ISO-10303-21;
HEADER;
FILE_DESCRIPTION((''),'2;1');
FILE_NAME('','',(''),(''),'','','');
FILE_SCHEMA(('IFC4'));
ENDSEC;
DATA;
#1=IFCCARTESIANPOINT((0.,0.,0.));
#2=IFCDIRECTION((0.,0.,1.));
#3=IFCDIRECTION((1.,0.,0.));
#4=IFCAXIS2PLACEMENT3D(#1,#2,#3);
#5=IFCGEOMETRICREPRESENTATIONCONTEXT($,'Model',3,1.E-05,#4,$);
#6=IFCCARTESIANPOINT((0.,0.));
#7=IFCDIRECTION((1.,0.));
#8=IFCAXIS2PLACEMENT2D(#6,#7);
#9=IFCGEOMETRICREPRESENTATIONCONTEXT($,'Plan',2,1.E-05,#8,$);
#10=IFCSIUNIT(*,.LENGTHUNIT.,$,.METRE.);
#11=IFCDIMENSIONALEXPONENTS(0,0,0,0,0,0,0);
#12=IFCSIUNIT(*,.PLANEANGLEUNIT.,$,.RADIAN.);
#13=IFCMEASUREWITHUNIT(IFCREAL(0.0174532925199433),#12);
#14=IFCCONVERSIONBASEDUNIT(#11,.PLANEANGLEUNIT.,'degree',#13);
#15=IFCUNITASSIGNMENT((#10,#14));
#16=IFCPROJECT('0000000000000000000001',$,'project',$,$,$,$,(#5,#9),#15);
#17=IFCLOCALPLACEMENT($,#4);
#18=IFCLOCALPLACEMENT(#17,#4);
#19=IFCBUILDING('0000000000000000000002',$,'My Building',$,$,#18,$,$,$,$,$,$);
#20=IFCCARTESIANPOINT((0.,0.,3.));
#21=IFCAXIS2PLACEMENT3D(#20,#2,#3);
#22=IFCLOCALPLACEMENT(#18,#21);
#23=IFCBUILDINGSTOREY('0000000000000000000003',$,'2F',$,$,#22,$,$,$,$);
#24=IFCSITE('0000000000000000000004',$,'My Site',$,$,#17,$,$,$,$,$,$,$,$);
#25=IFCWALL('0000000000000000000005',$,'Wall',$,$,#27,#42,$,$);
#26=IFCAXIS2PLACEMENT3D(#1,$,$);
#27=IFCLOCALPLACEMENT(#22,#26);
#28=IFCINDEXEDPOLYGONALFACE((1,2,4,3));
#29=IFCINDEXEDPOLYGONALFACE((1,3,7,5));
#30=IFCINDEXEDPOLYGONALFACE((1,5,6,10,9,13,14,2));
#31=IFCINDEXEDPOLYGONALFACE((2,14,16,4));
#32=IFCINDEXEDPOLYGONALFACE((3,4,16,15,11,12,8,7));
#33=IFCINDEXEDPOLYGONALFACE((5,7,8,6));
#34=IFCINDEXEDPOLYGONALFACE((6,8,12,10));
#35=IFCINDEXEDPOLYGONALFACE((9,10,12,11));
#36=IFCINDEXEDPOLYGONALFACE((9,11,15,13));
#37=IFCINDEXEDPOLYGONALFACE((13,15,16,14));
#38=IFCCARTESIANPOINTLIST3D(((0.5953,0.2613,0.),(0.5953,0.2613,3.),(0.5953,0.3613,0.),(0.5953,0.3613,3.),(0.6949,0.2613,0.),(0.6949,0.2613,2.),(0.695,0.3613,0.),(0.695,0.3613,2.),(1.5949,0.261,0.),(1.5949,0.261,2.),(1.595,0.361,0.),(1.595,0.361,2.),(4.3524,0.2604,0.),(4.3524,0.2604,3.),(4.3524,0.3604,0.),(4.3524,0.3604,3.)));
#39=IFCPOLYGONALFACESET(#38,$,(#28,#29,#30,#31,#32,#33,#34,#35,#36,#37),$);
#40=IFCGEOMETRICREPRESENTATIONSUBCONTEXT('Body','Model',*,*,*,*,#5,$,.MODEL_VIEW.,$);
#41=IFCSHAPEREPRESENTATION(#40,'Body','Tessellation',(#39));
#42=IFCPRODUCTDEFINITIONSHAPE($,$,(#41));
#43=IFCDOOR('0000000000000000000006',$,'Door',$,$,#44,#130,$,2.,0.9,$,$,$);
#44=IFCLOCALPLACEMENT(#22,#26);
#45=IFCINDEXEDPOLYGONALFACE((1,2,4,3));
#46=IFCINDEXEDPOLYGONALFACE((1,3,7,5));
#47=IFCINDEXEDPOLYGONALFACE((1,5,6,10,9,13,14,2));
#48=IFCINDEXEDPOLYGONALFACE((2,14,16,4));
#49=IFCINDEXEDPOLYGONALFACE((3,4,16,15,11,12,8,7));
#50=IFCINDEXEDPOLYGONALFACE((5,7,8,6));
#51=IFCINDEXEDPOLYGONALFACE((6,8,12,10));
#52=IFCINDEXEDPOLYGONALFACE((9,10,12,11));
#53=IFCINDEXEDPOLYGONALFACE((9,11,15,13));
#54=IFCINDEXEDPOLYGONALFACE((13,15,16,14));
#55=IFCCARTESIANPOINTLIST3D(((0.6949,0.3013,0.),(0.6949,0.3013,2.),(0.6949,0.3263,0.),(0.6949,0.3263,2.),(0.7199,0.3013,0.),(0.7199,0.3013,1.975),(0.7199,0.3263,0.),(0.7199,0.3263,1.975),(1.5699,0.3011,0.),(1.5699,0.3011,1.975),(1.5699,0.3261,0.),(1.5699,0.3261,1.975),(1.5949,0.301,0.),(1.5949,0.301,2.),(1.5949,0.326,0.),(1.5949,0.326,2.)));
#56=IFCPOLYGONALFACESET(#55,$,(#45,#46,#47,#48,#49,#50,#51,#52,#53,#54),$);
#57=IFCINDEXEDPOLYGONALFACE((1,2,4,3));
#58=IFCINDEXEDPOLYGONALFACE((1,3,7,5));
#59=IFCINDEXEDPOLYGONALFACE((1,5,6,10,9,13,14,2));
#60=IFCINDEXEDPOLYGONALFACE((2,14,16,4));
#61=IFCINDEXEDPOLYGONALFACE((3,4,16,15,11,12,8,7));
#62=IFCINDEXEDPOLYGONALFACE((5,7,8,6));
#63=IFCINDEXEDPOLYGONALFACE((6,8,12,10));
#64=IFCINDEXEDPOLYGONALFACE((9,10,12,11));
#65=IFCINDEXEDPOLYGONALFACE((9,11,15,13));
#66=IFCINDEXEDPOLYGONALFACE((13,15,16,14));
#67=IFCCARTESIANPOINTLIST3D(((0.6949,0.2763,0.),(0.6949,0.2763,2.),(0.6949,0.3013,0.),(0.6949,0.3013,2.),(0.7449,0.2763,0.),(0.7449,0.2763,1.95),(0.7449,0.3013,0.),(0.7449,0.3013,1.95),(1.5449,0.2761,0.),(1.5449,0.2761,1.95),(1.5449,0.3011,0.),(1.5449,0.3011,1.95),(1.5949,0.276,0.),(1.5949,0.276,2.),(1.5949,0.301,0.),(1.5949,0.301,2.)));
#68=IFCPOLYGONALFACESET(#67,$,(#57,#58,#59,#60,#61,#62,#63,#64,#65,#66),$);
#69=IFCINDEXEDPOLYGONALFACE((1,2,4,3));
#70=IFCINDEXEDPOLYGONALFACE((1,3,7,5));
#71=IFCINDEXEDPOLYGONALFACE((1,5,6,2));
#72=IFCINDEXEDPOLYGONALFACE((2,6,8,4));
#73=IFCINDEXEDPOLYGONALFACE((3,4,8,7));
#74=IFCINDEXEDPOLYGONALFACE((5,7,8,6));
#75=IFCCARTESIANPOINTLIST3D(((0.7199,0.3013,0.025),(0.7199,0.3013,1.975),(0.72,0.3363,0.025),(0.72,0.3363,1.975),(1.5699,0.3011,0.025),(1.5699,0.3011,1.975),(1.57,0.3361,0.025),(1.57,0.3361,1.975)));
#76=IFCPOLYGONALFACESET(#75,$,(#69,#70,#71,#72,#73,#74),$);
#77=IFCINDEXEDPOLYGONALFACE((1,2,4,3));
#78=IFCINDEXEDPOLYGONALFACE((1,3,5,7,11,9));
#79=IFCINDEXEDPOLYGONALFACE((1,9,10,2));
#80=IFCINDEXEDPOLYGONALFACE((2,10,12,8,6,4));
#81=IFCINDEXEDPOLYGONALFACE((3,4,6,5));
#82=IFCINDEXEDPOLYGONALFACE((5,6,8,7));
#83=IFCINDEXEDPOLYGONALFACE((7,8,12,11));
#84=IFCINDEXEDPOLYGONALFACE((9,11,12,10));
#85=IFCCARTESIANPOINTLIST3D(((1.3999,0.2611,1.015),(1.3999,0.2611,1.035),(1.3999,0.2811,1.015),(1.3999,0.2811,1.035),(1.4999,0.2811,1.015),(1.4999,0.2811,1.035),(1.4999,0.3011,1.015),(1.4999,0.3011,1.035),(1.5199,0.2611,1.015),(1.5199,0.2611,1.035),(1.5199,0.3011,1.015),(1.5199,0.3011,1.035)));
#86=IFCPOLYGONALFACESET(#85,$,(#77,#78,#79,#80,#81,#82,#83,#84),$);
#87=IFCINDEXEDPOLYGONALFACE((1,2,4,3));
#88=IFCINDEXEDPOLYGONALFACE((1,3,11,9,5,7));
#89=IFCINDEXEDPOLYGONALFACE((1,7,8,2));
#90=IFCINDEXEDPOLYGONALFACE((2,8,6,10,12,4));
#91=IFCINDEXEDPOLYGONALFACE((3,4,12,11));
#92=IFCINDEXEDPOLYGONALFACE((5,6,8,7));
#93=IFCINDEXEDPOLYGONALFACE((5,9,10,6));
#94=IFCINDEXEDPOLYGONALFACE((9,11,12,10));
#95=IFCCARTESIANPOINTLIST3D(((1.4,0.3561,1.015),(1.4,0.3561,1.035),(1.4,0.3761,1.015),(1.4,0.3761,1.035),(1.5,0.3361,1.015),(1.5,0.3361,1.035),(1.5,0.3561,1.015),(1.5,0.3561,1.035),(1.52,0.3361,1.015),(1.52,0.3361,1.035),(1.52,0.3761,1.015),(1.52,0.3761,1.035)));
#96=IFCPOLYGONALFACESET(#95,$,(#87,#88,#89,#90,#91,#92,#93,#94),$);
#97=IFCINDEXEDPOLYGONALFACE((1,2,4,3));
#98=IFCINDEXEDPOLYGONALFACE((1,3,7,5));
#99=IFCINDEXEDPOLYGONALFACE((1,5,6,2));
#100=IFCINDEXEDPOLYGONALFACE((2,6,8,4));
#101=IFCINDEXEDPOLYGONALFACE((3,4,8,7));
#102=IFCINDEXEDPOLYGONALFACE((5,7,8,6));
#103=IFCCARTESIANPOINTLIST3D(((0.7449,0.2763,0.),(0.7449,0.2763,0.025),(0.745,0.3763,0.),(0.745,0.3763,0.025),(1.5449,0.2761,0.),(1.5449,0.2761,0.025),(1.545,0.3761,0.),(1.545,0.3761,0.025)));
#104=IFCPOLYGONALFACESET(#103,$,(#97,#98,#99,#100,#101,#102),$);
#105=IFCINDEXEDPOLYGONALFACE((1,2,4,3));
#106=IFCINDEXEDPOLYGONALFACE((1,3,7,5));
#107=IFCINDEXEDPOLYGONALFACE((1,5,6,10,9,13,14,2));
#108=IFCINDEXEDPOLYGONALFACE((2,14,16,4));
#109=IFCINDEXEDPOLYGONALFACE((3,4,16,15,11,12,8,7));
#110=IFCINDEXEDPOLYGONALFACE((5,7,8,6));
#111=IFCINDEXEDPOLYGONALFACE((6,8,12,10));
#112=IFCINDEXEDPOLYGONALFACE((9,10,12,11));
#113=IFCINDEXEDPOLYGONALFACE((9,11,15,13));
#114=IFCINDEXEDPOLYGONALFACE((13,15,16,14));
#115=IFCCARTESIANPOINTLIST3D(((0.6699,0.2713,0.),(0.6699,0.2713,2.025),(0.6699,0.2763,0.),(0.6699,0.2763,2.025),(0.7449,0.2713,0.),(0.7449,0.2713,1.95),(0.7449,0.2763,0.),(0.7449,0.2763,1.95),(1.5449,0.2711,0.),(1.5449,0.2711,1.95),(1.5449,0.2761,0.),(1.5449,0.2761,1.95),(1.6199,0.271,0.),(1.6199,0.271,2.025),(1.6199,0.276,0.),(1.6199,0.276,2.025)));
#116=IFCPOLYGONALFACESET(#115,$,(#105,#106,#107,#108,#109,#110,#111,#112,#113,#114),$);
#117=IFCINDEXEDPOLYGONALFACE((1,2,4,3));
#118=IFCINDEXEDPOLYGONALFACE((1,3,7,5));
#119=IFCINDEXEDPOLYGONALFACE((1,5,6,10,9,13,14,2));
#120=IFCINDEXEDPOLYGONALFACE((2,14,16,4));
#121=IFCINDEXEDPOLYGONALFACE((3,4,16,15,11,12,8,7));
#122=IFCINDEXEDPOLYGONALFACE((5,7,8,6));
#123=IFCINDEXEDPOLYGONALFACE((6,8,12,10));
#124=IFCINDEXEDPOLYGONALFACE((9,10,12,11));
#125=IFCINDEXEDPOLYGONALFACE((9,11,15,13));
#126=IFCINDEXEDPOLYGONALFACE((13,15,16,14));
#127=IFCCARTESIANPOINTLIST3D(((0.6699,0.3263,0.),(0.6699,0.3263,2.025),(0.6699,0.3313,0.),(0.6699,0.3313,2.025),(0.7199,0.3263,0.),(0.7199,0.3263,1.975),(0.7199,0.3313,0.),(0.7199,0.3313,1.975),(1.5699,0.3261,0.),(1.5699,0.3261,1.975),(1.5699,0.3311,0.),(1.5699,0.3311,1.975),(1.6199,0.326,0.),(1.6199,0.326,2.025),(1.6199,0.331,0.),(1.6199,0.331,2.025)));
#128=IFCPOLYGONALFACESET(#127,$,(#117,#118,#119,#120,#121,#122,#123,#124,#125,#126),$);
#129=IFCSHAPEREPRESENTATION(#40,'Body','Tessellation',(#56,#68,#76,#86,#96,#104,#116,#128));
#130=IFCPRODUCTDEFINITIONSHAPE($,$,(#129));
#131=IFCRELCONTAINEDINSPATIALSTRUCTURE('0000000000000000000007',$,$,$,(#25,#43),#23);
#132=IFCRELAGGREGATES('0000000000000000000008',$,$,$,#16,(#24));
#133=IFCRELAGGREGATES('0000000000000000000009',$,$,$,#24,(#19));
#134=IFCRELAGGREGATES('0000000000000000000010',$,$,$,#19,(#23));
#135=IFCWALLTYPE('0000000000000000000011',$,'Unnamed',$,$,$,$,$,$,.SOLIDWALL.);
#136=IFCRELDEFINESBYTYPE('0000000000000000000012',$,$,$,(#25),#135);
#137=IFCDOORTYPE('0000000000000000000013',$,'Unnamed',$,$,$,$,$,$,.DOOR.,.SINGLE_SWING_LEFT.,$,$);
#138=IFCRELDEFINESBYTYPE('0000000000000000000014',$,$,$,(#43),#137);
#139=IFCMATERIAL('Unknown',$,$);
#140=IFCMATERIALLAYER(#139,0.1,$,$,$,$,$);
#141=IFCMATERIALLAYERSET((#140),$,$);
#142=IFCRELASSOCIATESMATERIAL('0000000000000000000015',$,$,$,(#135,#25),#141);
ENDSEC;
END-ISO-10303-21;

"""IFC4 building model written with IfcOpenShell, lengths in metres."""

from ifc_helpers import new_model, entity, si_unit, converted_unit, frame, origin_with_axes, origin_2d_with_axis, place, context, subcontext, project, spatial, line, indexed_curve, outline, extrude, shape, source, transform, mapped, material, layer, layer_set, layer_usage, type_object, type_shapes, element, fill, save


model = new_model("IFC4")

# Units and contexts
model_context = context("Model", 3, precision=1e-05, world=origin_with_axes())
plan_context = context("Plan", 2, precision=1e-05, world=origin_2d_with_axis())
body_context_1 = subcontext(model_context, "Body", "Model", "MODEL_VIEW")
body_context_2 = subcontext(plan_context, "Body", "Plan", "PLAN_VIEW")
ifc_project = project(units=[si_unit("LENGTHUNIT", "METRE"), converted_unit("PLANEANGLEUNIT", "degree", entity("IfcReal", 0.0174532925199433), si_unit("PLANEANGLEUNIT", "RADIAN"), dimensions=[0, 0, 0, 0, 0, 0, 0])], contexts=[model_context, plan_context])

# Site, building, storey
site_placement = place(None, origin_with_axes())
site = spatial("IfcSite", under=ifc_project, at=site_placement, Name="My Site")
building_placement = place(site_placement, origin_with_axes())
building = spatial("IfcBuilding", under=site, at=building_placement, Name="My Building")
storey_placement = place(building_placement, frame((0.0, 0.0, 3.0), z_axis=(0.0, 0.0, 1.0), x_axis=(1.0, 0.0, 0.0)))
storey = spatial("IfcBuildingStorey", under=building, at=storey_placement, Name="2F")

# Shared definitions
ifc_material = material(Name="Unknown")

# Shared definitions
ifc_layer_1 = layer(ifc_material, 0.1)
ifc_layer_set_1 = layer_set([ifc_layer_1])
wall_type = type_object("IfcWallType", Name="Unnamed", PredefinedType="SOLIDWALL", material=ifc_layer_set_1)

# Shared definitions
shared_shape_1 = source(origin_with_axes(), body_context_1, "Body", "SweptSolid", [
    extrude(outline(indexed_curve([(0.0, 0.0), (0.9, 0.0), (0.9, 2.0), (0.0, 2.0)], segments=[line(1, 2, 3, 4, 1)])), frame((0.0, -0.6, 0.0), z_axis=(0.0, -1.0, 0.0), x_axis=(1.0, 0.0, 0.0)), (0.0, 0.0, -1.0), 1.2),
])
door_type = type_object("IfcDoorType", Name="Unnamed", OperationType="SINGLE_SWING_LEFT", PredefinedType="DOOR")
shared_shape_2 = source(origin_with_axes(), body_context_1, "Body", "SweptSolid", [
    extrude(outline(indexed_curve([(0.0, 0.0), (0.0, 2.0), (0.9, 2.0), (0.9, 0.0), (0.875, 0.0), (0.875, 1.975), (0.025, 1.975), (0.025, 0.0)], segments=[line(1, 2, 3, 4, 5, 6, 7, 8, 1)])), frame((0.0, 0.025, 0.0), z_axis=(0.0, -1.0, 0.0), x_axis=(1.0, 0.0, 0.0)), (0.0, 0.0, -1.0), 0.025),
    extrude(outline(indexed_curve([(0.0, 0.0), (0.0, 2.0), (0.9, 2.0), (0.9, 0.0), (0.85, 0.0), (0.85, 1.95), (0.05, 1.95), (0.05, 0.0)], segments=[line(1, 2, 3, 4, 5, 6, 7, 8, 1)])), frame((0.0, 0.0, 0.0), z_axis=(0.0, -1.0, 0.0), x_axis=(1.0, 0.0, 0.0)), (0.0, 0.0, -1.0), 0.025),
    extrude(outline(indexed_curve([(0.0, 0.0), (0.85, 0.0), (0.85, 0.035), (0.0, 0.035)], segments=[line(1, 2, 3, 4, 1)])), frame((0.025, 0.025, 0.025), z_axis=(0.0, 0.0, 1.0), x_axis=(1.0, 0.0, 0.0)), (0.0, 0.0, 1.0), 1.95),
    extrude(outline(indexed_curve([(0.0, 0.0), (0.0, -0.04), (-0.12, -0.04), (-0.12, -0.02), (-0.02, -0.02), (-0.02, 0.0)], segments=[line(1, 2, 3, 4, 5, 6, 1)])), frame((0.825, 0.025, 1.015), z_axis=(0.0, 0.0, 1.0), x_axis=(1.0, 0.0, 0.0)), (0.0, 0.0, 1.0), 0.02),
    extrude(outline(indexed_curve([(0.0, 0.0), (0.0, 0.04), (-0.12, 0.04), (-0.12, 0.02), (-0.02, 0.02), (-0.02, 0.0)], segments=[line(1, 2, 3, 4, 5, 6, 1)])), frame((0.825, 0.06, 1.015), z_axis=(0.0, 0.0, 1.0), x_axis=(1.0, 0.0, 0.0)), (0.0, 0.0, 1.0), 0.02),
    extrude(outline(indexed_curve([(0.0, 0.0), (0.8, 0.0), (0.8, 0.1), (0.0, 0.1)], segments=[line(1, 2, 3, 4, 1)])), frame((0.05, 0.0, 0.0), z_axis=(0.0, 0.0, 1.0), x_axis=(1.0, 0.0, 0.0)), (0.0, 0.0, 1.0), 0.025),
    extrude(outline(indexed_curve([(0.0, 0.0), (0.0, 2.025), (0.95, 2.025), (0.95, 0.0), (0.875, 0.0), (0.875, 1.95), (0.075, 1.95), (0.075, 0.0)], segments=[line(1, 2, 3, 4, 5, 6, 7, 8, 1)])), frame((-0.025, -0.005, 0.0), z_axis=(0.0, -1.0, 0.0), x_axis=(1.0, 0.0, 0.0)), (0.0, 0.0, -1.0), 0.005),
    extrude(outline(indexed_curve([(0.0, 0.0), (0.0, 2.025), (0.95, 2.025), (0.95, 0.0), (0.9, 0.0), (0.9, 1.975), (0.05, 1.975), (0.05, 0.0)], segments=[line(1, 2, 3, 4, 5, 6, 7, 8, 1)])), frame((-0.025, 0.05, 0.0), z_axis=(0.0, -1.0, 0.0), x_axis=(1.0, 0.0, 0.0)), (0.0, 0.0, -1.0), 0.005),
])
shared_shape_3 = source(origin_with_axes(), body_context_2, "Body", "Curve2D", [
    entity("IfcIndexedPolyCurve", entity("IfcCartesianPointList2D", [[0.0, 0.0], [0.0, 0.05], [0.025, 0.05], [0.025, 0.025], [0.05, 0.025], [0.05, 0.0]]), [entity("IfcLineIndex", [1, 2, 3, 4, 5, 6, 1])]),
    entity("IfcIndexedPolyCurve", entity("IfcCartesianPointList2D", [[0.9, 0.0], [0.9, 0.05], [0.875, 0.05], [0.875, 0.025], [0.85, 0.025], [0.85, 0.0]]), [entity("IfcLineIndex", [1, 2, 3, 4, 5, 6, 1])]),
    entity("IfcTrimmedCurve", entity("IfcEllipse", entity("IfcAxis2Placement2D", entity("IfcCartesianPoint", [0.06, 0.05]), entity("IfcDirection", [1.0, 0.0])), 0.815, 0.85), [entity("IfcCartesianPoint", [0.875, 0.05])], [entity("IfcCartesianPoint", [0.06, 0.9])], True, "CARTESIAN"),
    entity("IfcIndexedPolyCurve", entity("IfcCartesianPointList2D", [[0.025, 0.05], [0.06, 0.05], [0.06, 0.9], [0.025, 0.9]]), [entity("IfcLineIndex", [1, 2, 3, 4, 1])]),
])
type_shapes(door_type, [shared_shape_2, shared_shape_3])

# Wall, opening, door
ifc_layer_usage_1 = layer_usage(ifc_layer_set_1, "AXIS2", "POSITIVE", 0.0)
wall_1_placement = place(storey_placement, frame((4.3524, 0.3604, 0.0), z_axis=(0.0, 0.0, 1.0), x_axis=(-1.0, 0.000251, 0.0)))
wall_1 = element("IfcWall", 1, at=wall_1_placement, inside=storey, type_object=wall_type, material=ifc_layer_usage_1, Name="Wall", context=body_context_1, shape_type="SweptSolid", body=[
    extrude(outline(indexed_curve([(0.0, 0.0), (0.0, 0.1), (3.7571, 0.1), (3.7571, 0.0)], segments=[line(1, 2, 3, 4, 1)])), origin_with_axes(), (0.0, 0.0, 1.0), 3.0),
])
opening_1_placement = place(wall_1_placement, frame((2.7574, 0.0, 0.0), z_axis=(0.0, 0.0, 1.0), x_axis=(1.0, 0.0, 0.0)))
opening_1 = element("IfcOpeningElement", 2, at=opening_1_placement, cuts=wall_1, PredefinedType="OPENING", context=body_context_1, shape_type="MappedRepresentation", body=[
    mapped(shared_shape_1, transform((0.0, 0.0, 0.0), x_axis=(1.0, 0.0, 0.0), y_axis=(0.0, 1.0, 0.0), z_axis=(0.0, 0.0, 1.0), scale=1.0)),
])
door_1_placement = place(opening_1_placement, frame((0.9, 0.085, 0.0), z_axis=(0.0, 0.0, 1.0), x_axis=(-1.0, 0.0, 0.0)))
door_1 = element("IfcDoor", 3, at=door_1_placement, inside=storey, type_object=door_type, Name="Door", OverallHeight=2.0, OverallWidth=0.9, shapes=[
    shape(body_context_1, "Body", "MappedRepresentation", [mapped(shared_shape_2, transform((0.0, 0.0, 0.0), x_axis=(1.0, 0.0, 0.0), y_axis=(0.0, 1.0, 0.0), z_axis=(0.0, 0.0, 1.0), scale=1.0))]),
    shape(body_context_2, "Body", "MappedRepresentation", [mapped(shared_shape_3, transform((0.0, 0.0, 0.0), x_axis=(1.0, 0.0, 0.0), y_axis=(0.0, 1.0, 0.0), z_axis=(0.0, 0.0, 1.0), scale=1.0))]),
])
fill(opening_1, door_1)

save(model, "model.ifc")
